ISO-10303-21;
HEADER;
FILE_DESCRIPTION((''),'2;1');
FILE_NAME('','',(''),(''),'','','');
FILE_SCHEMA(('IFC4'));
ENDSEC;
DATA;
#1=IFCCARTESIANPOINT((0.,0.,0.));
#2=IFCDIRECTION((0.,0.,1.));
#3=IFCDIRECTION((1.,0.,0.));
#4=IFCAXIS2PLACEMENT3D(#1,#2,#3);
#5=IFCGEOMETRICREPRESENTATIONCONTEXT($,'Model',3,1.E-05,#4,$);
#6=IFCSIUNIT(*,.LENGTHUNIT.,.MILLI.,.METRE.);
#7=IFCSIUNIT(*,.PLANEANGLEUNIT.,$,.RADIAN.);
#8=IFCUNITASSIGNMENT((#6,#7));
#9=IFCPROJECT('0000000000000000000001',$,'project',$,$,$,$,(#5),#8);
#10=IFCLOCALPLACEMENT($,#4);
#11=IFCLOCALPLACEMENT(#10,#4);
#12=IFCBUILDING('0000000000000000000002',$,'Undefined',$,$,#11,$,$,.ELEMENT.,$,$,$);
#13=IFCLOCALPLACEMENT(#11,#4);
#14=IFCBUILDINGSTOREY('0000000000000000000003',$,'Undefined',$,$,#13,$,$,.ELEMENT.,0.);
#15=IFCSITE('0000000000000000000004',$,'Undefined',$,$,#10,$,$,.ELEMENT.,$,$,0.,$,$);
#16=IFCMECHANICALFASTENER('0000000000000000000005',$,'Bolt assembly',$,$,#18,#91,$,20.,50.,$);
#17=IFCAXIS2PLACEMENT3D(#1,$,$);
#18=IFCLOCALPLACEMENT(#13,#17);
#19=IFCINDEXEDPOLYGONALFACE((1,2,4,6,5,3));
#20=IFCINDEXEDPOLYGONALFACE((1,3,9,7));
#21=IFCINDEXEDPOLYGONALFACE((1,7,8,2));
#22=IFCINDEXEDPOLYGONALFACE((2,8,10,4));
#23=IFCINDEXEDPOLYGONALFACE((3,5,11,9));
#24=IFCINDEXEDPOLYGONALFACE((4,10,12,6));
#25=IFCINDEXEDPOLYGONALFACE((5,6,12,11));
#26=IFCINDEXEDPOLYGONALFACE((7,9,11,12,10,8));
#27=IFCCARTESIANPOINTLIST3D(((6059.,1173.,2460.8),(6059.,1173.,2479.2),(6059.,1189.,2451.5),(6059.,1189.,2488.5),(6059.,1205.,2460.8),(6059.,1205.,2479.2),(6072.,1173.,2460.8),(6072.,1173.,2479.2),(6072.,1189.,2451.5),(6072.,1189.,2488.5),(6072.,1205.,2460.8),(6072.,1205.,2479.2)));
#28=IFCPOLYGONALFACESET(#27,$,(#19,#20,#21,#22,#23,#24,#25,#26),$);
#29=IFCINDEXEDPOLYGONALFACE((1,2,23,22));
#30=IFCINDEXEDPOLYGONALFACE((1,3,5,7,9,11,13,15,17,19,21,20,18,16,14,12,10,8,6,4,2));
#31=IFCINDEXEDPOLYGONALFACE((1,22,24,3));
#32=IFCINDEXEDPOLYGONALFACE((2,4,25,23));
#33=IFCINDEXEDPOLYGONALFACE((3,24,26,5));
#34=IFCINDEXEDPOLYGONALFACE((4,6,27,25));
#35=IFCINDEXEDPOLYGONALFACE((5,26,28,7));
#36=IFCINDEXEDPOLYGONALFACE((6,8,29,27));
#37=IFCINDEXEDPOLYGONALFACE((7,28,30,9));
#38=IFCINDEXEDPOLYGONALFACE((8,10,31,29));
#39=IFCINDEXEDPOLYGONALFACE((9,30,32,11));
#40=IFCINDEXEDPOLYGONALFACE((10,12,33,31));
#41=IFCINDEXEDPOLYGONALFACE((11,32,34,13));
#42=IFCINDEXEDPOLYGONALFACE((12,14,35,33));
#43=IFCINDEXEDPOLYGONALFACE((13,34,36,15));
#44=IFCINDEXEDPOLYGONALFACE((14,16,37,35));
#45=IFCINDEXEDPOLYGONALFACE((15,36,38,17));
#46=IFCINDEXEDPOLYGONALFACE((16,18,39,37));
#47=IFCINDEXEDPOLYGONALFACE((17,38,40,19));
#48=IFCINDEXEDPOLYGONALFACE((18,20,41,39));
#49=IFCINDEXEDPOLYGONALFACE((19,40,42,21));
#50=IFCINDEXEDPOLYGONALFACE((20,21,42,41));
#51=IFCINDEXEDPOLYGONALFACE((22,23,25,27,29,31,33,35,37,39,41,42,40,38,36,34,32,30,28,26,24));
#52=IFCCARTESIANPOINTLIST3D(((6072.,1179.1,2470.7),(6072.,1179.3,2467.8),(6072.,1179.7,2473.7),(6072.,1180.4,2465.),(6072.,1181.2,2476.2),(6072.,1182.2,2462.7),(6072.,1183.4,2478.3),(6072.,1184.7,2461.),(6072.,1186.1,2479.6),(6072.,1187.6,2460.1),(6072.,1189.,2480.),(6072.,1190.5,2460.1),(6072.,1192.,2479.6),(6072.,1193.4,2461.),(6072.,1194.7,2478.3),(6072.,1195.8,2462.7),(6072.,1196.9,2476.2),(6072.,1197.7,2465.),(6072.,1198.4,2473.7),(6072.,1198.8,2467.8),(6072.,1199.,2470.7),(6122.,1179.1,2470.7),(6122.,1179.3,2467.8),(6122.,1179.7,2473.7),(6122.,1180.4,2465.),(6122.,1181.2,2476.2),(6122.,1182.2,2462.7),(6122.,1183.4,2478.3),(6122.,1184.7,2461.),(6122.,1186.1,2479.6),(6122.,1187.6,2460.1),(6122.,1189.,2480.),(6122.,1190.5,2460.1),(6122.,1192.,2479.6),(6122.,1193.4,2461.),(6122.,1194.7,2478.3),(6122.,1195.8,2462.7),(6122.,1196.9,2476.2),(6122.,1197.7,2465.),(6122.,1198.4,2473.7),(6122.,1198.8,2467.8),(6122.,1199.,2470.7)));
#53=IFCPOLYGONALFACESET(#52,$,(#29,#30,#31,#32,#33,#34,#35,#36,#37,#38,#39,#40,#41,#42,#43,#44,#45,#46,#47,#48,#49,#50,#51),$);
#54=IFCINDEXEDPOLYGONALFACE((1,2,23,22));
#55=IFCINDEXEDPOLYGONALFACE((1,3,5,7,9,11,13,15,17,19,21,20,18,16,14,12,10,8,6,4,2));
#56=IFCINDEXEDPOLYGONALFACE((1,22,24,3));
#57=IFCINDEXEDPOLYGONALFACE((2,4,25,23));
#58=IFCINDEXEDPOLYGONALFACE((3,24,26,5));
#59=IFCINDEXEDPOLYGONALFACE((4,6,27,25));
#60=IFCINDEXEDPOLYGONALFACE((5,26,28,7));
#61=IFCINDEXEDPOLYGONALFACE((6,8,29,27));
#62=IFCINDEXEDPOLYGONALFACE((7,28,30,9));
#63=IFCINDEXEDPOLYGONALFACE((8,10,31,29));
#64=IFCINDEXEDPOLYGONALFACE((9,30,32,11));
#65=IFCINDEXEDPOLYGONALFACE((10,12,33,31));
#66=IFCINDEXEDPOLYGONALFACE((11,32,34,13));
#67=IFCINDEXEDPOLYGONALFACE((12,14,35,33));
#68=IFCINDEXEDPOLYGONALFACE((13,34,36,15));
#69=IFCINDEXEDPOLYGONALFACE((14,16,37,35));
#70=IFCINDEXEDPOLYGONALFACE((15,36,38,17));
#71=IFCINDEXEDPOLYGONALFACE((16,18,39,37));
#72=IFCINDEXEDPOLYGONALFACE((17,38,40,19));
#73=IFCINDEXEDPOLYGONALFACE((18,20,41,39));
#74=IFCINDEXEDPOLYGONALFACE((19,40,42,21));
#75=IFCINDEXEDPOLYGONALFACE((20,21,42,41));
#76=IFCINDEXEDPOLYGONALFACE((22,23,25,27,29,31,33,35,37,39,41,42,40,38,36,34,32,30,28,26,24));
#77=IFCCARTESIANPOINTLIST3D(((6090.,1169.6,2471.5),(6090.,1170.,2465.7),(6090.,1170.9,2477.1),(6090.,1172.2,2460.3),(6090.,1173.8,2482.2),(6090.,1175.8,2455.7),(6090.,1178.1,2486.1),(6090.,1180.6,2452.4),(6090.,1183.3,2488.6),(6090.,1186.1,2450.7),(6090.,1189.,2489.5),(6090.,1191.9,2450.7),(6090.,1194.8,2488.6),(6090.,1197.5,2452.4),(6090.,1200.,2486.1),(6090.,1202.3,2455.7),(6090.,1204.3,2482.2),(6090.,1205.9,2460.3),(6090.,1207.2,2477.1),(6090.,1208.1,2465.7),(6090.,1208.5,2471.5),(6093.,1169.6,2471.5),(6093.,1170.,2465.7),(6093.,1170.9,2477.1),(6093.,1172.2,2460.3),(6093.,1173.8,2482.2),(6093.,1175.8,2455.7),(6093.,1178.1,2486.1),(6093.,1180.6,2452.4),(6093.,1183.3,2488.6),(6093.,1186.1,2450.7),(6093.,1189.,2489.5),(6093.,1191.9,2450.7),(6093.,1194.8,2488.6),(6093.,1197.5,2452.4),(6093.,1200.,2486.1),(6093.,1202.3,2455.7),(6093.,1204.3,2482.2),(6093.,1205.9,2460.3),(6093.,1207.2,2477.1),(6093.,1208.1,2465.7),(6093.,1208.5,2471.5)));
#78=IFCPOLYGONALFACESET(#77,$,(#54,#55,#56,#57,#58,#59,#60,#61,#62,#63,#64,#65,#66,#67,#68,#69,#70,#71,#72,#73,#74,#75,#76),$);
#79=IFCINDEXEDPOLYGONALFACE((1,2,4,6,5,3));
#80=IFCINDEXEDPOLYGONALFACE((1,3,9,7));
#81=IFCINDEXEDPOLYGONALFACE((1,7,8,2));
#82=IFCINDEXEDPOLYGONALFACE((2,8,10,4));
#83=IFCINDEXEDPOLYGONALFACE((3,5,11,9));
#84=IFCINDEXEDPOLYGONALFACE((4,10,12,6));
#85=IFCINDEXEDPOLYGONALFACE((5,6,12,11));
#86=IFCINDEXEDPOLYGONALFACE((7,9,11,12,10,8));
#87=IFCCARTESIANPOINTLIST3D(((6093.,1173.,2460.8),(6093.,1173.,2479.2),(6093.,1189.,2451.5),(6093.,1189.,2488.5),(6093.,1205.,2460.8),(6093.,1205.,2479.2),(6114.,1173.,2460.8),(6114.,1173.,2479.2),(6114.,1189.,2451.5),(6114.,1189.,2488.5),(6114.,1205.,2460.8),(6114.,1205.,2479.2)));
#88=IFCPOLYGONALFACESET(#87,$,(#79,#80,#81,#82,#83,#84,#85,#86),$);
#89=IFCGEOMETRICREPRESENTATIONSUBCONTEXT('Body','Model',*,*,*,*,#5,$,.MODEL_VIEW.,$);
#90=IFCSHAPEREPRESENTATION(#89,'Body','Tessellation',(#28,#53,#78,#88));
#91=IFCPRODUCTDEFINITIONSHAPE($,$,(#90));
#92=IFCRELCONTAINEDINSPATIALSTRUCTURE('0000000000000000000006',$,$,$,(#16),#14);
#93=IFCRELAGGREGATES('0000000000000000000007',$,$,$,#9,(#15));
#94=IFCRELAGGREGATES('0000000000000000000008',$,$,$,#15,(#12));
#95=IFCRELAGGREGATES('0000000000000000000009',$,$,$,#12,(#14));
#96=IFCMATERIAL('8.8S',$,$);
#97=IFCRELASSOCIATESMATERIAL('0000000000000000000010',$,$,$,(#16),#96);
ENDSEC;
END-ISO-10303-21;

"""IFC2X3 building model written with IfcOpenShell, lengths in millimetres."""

from ifc_helpers import new_model, si_unit, frame, origin_with_axes, origin_2d_with_axis, place, context, subcontext, project, spatial, polyline, circle, outline, extrude, source, transform, mapped, material, element, save


model = new_model("IFC2X3")

# Units and contexts
model_context = context("Model", 3, precision=1e-05, world=origin_with_axes())
body_context = subcontext(model_context, "Body", "Model", "MODEL_VIEW")
ifc_project = project(units=[si_unit("LENGTHUNIT", "METRE", prefix="MILLI"), si_unit("PLANEANGLEUNIT", "RADIAN")], contexts=[model_context])

# Site, building, storey
site_placement = place(None, origin_with_axes())
site = spatial("IfcSite", under=ifc_project, at=site_placement, Name="Undefined", CompositionType="ELEMENT", RefElevation=0.0)
building_placement = place(site_placement, origin_with_axes())
building = spatial("IfcBuilding", under=site, at=building_placement, Name="Undefined", CompositionType="ELEMENT")
storey_placement = place(building_placement, origin_with_axes())
storey = spatial("IfcBuildingStorey", under=building, at=storey_placement, Name="Undefined", CompositionType="ELEMENT", Elevation=0.0)

# Mechanical fastener
ifc_material_1 = material(Name="8.8S")
shared_shape_1 = source(origin_with_axes(), body_context, "Body", "SweptSolid", [
    extrude(outline(polyline([(18.5, 0.0), (9.2, 16.0), (-9.2, 16.0), (-18.5, 0.0), (-9.2, -16.0), (9.2, -16.0), (18.5, 0.0)])), frame((0.0, -23.0, 0.0), z_axis=(0.0, 1.0, 0.0), x_axis=(1.0, 0.0, 0.0)), (0.0, 0.0, 1.0), 13.0),
    extrude(circle(Radius=10.0, at=origin_2d_with_axis()), frame((0.0, -10.0, 0.0), z_axis=(0.0, 1.0, 0.0), x_axis=(1.0, 0.0, 0.0)), (0.0, 0.0, 1.0), 50.0),
    extrude(circle(Radius=19.5, at=origin_2d_with_axis()), frame((0.0, 8.0, 0.0), z_axis=(0.0, 1.0, 0.0), x_axis=(1.0, 0.0, 0.0)), (0.0, 0.0, 1.0), 3.0),
    extrude(outline(polyline([(18.5, 0.0), (9.2, 16.0), (-9.2, 16.0), (-18.5, 0.0), (-9.2, -16.0), (9.2, -16.0), (18.5, 0.0)])), frame((0.0, 11.0, 0.0), z_axis=(0.0, 1.0, 0.0), x_axis=(1.0, 0.0, 0.0)), (0.0, 0.0, 1.0), 21.0),
])
for number, where, z_axis, x_axis, name in (
    (1, (6082.0, 1189.0, 2470.0), (0.0, 1.0, 0.0), (-0.000022, 0.0, 1.0), "Bolt assembly"),
):
    element("IfcMechanicalFastener", number, at=place(storey_placement, frame(where, z_axis=z_axis, x_axis=x_axis)), inside=storey, material=ifc_material_1, Name=name, NominalDiameter=20.0, NominalLength=50.0, context=body_context, shape_type="MappedRepresentation", body=[
        mapped(shared_shape_1, transform((0.0, 0.0, 0.0))),
    ])

save(model, "model.ifc")
